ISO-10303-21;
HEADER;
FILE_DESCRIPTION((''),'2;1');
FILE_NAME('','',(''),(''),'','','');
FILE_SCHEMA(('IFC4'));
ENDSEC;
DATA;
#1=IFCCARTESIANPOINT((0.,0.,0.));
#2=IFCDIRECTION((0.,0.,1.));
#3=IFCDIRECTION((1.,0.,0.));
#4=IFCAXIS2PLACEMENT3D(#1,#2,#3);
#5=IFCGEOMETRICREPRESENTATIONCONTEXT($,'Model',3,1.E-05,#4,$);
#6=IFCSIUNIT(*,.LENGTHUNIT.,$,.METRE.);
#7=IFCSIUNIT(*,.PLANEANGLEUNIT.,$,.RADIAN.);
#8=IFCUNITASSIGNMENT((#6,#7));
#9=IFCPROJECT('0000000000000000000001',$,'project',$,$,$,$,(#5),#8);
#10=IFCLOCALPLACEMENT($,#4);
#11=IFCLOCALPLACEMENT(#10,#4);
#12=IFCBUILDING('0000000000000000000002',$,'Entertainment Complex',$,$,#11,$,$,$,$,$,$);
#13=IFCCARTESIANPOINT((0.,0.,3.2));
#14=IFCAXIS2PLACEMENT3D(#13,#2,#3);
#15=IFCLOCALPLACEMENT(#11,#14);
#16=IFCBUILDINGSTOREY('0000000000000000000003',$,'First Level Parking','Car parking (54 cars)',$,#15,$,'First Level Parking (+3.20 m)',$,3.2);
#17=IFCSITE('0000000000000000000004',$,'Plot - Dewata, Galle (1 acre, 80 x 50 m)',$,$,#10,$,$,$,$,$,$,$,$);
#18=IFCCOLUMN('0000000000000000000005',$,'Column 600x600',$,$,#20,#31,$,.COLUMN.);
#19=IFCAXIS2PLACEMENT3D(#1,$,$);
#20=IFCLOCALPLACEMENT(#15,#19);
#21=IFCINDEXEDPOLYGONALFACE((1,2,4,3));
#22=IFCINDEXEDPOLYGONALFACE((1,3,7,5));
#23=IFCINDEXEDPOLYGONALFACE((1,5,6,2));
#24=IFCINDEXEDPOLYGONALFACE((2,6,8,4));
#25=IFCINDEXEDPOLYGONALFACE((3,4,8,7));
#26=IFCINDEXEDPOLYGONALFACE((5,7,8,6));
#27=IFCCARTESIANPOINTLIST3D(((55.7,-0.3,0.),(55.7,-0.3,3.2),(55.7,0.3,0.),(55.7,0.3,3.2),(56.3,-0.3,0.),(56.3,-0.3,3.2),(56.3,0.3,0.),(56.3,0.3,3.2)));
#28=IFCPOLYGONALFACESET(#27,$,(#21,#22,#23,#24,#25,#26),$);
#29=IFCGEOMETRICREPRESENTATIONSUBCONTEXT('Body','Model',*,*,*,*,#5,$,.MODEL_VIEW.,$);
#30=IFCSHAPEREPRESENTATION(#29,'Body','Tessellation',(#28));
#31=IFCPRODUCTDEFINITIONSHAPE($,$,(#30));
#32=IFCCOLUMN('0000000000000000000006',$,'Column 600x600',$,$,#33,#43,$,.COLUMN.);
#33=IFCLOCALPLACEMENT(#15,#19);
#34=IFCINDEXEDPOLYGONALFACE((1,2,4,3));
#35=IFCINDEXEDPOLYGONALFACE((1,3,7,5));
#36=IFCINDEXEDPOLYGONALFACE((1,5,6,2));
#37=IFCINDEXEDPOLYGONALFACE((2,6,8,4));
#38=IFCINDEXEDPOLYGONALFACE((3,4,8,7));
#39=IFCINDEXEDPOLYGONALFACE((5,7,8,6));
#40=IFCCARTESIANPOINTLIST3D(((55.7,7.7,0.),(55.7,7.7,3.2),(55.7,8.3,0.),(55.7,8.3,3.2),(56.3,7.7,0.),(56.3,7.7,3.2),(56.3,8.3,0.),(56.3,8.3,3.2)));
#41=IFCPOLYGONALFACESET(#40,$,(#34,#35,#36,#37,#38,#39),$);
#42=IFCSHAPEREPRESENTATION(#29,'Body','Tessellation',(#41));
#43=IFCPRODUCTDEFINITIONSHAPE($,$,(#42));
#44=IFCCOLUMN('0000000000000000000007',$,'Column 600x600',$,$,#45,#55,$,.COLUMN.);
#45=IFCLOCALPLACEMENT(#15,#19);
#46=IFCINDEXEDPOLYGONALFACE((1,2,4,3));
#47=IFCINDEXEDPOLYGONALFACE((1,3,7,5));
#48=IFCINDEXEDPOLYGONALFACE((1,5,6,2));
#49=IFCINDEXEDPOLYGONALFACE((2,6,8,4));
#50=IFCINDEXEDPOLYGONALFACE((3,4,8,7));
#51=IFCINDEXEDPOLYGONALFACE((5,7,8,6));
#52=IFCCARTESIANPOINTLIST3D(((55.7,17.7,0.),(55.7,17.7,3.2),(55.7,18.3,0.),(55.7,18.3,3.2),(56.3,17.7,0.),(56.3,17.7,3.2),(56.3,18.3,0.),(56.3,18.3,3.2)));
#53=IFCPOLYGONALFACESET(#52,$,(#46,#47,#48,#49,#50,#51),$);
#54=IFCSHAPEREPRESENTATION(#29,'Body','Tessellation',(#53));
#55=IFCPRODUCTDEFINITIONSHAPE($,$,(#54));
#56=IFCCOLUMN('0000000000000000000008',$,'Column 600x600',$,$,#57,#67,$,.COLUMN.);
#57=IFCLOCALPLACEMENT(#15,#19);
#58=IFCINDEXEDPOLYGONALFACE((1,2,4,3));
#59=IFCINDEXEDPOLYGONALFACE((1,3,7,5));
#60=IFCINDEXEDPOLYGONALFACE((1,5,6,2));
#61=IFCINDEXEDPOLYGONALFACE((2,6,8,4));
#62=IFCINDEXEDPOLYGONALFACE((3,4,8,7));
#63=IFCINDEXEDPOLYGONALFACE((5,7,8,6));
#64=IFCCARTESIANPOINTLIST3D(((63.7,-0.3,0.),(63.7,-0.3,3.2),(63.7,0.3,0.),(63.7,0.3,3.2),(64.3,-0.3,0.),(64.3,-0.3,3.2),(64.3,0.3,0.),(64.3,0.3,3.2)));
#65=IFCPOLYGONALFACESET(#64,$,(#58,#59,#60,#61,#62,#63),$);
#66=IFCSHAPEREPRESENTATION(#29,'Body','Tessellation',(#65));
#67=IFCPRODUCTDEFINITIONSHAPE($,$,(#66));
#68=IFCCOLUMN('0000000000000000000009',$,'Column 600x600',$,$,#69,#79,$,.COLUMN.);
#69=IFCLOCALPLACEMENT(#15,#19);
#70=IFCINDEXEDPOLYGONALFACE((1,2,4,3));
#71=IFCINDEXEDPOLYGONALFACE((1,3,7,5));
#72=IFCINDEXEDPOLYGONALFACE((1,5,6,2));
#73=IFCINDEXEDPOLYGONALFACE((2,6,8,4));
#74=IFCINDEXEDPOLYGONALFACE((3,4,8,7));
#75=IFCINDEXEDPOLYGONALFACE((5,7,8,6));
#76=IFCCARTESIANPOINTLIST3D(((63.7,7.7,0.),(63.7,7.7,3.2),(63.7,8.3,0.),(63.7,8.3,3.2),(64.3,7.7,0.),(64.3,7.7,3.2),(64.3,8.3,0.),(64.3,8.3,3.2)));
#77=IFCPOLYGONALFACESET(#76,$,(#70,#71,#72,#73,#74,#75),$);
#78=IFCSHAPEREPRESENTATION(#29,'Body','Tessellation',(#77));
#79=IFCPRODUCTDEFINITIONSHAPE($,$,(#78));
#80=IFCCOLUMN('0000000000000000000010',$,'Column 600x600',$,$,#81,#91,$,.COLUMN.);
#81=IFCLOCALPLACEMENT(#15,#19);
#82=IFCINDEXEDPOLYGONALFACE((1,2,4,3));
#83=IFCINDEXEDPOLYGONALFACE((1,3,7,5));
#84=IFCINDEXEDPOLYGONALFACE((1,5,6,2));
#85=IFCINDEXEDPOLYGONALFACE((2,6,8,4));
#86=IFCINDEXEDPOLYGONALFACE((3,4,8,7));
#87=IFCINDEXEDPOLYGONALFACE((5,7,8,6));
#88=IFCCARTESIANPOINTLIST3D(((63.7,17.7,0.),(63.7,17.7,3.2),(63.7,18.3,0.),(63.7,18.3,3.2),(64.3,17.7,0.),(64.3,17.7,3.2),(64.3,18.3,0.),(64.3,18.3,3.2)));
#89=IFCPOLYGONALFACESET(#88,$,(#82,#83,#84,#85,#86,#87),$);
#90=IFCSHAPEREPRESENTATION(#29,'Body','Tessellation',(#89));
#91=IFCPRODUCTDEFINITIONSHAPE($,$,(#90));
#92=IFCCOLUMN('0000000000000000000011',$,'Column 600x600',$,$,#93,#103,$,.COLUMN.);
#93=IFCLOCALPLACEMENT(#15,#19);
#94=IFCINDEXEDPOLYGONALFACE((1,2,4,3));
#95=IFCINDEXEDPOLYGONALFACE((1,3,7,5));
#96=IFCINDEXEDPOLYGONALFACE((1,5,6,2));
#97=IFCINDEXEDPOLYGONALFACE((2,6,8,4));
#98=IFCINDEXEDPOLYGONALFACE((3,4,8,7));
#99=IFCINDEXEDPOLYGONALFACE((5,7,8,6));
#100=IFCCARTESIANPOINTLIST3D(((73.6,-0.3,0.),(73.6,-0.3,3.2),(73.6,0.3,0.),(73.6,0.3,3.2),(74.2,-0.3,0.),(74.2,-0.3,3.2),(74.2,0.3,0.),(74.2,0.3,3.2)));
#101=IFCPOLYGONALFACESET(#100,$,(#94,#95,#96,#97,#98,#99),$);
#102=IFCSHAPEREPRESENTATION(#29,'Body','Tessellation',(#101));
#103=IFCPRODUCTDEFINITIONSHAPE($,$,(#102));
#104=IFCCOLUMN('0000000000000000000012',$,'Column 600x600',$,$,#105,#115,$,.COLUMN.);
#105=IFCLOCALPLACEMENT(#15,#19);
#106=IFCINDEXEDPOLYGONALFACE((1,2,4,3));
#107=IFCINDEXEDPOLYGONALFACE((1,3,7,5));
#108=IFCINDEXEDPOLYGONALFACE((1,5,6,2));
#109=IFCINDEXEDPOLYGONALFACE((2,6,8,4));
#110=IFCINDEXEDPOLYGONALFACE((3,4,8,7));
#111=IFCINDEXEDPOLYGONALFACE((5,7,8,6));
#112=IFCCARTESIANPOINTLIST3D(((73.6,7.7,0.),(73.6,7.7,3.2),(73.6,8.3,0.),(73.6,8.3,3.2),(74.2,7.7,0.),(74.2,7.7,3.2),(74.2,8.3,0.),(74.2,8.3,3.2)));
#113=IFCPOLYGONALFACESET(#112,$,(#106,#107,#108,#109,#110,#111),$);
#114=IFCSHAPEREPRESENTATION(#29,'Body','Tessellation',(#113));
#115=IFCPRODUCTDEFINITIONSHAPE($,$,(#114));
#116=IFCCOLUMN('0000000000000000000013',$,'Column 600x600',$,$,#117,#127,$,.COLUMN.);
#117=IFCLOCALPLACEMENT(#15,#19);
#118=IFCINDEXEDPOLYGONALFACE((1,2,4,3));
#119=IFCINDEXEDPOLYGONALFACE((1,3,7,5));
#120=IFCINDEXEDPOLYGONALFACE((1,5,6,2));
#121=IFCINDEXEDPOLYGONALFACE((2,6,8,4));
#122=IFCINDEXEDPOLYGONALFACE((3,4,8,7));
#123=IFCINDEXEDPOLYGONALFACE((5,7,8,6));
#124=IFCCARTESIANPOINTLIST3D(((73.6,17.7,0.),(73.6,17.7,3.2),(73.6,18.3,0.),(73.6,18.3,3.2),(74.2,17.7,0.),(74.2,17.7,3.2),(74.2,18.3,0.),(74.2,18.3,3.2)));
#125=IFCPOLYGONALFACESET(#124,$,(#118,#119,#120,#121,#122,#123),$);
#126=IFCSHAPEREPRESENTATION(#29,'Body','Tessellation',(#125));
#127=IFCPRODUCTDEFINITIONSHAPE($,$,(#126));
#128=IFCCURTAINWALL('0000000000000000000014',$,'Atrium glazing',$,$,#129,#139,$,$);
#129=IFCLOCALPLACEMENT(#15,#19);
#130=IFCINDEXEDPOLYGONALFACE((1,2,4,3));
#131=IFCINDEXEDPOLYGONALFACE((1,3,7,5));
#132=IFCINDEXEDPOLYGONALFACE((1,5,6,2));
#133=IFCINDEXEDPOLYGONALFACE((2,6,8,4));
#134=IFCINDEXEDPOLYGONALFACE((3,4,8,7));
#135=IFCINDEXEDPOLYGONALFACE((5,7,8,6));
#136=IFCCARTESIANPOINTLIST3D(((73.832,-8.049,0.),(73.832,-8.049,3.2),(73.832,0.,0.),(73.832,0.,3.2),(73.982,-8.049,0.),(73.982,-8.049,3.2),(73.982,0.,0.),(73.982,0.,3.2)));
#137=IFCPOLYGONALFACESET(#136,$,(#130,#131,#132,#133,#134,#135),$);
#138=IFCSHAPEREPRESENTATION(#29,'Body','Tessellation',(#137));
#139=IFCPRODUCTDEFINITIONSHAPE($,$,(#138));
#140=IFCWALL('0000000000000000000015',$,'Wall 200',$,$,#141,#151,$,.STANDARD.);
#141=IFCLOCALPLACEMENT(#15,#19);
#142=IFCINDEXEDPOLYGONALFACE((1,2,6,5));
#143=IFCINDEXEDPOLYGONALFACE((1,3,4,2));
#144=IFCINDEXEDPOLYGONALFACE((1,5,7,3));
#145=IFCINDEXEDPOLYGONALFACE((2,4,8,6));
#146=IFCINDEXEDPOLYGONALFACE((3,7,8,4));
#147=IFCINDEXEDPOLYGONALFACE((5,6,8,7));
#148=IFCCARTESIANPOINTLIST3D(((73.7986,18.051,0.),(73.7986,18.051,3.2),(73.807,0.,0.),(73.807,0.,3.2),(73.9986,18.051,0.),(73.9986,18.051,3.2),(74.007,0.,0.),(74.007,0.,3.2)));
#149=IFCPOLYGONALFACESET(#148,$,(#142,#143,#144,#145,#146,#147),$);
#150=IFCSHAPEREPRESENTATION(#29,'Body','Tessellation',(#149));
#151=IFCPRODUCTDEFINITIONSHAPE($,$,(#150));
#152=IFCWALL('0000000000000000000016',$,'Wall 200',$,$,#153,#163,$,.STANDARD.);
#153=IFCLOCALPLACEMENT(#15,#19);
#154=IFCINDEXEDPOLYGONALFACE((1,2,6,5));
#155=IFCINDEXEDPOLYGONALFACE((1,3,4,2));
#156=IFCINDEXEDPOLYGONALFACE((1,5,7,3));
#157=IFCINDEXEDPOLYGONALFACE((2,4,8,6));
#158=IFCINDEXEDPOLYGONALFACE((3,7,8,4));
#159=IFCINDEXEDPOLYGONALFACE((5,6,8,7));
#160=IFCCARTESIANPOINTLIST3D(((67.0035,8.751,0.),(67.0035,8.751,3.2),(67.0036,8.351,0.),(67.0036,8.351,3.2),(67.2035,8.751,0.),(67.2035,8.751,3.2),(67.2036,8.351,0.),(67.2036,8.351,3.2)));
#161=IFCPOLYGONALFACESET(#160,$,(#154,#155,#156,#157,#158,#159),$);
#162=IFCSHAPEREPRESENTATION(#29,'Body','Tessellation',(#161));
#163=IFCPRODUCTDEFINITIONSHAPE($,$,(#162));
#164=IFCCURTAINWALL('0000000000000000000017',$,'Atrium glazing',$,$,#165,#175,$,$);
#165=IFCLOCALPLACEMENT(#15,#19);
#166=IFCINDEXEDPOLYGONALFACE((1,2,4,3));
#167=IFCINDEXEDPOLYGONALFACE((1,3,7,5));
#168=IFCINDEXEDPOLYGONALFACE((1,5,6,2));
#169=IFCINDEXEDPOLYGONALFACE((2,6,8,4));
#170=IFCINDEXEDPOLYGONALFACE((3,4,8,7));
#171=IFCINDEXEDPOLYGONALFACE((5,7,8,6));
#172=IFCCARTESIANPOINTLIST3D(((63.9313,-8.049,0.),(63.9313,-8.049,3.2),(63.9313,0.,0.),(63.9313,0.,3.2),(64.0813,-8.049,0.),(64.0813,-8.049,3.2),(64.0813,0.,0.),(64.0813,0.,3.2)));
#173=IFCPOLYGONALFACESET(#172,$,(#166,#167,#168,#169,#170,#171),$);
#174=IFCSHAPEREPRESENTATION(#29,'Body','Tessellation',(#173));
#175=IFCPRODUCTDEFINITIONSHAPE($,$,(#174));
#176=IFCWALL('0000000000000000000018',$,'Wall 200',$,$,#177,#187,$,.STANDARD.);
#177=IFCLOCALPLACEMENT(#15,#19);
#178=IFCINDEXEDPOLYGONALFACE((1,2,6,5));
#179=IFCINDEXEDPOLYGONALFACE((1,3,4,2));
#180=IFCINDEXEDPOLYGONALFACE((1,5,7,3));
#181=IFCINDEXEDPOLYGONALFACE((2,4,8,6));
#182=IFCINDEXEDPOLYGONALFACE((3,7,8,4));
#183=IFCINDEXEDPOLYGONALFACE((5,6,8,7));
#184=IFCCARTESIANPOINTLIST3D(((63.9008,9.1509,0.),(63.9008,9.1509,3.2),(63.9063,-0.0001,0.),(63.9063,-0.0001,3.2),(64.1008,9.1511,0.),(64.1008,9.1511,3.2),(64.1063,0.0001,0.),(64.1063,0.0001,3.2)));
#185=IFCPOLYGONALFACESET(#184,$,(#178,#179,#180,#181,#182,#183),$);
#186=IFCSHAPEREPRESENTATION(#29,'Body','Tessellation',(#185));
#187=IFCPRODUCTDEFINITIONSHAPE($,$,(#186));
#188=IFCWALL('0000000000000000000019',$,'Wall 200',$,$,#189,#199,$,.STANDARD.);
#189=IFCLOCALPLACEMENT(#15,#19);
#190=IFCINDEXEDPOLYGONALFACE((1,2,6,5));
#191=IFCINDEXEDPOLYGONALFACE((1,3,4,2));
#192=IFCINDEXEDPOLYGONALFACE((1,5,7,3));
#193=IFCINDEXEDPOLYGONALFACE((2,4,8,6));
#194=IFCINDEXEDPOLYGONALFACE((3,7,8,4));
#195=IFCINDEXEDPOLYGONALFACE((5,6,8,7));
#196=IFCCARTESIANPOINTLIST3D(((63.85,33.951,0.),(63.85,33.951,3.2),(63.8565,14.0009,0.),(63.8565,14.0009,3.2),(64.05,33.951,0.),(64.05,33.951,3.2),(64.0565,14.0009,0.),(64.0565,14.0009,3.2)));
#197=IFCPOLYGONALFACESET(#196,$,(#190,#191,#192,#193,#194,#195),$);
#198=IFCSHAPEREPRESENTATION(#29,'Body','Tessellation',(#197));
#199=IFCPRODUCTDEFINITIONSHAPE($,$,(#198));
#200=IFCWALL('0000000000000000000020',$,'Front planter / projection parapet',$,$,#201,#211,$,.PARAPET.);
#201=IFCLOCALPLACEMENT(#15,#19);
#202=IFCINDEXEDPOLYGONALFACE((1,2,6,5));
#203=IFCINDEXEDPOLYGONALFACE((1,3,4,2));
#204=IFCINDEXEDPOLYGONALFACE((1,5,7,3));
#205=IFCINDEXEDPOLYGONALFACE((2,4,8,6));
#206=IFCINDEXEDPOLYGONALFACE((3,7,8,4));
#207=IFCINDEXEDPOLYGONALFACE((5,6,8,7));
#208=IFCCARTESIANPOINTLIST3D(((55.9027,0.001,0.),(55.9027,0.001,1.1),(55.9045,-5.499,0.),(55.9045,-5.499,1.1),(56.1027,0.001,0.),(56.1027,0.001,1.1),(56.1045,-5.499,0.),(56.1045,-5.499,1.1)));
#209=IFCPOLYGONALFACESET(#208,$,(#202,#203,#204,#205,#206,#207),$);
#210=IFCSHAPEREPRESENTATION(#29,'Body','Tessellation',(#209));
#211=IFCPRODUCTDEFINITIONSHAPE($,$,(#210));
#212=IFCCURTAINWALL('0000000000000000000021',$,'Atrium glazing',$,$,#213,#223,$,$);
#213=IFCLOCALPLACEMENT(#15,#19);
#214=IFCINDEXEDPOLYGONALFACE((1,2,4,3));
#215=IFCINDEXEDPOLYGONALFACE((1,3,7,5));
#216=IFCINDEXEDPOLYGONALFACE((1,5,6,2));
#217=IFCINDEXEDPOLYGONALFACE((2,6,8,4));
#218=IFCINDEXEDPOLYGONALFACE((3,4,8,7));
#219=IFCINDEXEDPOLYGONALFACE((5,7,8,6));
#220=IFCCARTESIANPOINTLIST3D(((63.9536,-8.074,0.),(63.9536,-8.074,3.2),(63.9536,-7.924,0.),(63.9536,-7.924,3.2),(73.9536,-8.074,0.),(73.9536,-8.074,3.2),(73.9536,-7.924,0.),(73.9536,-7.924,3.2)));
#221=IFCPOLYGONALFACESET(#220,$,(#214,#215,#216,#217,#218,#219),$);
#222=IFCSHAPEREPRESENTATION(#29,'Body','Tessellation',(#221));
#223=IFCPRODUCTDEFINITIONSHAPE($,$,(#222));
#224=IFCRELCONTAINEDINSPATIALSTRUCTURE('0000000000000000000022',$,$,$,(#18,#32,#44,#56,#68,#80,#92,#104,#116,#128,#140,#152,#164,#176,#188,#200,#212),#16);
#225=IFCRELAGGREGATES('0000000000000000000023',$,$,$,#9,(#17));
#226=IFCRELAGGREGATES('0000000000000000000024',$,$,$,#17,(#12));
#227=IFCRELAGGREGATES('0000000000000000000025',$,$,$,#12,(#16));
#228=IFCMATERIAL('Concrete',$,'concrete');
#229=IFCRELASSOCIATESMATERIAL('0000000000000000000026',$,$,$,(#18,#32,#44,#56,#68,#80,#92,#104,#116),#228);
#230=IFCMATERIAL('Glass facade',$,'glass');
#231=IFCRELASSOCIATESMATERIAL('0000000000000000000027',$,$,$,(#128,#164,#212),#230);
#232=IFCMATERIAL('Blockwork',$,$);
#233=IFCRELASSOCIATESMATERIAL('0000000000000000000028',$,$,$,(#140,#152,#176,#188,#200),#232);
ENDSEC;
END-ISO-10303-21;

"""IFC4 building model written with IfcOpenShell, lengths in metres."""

from ifc_helpers import new_model, si_unit, frame, origin_with_axes, place, context, subcontext, project, spatial, polyline, outline, extrude, material, element, save


model = new_model("IFC4")

# Units and contexts
model_context = context("Model", 3, precision=1e-05, world=origin_with_axes())
body_context = subcontext(model_context, "Body", "Model", "MODEL_VIEW")
ifc_project = project(units=[si_unit("LENGTHUNIT", "METRE"), si_unit("PLANEANGLEUNIT", "RADIAN")], contexts=[model_context])

# Site, building, storey
site_placement = place(None, origin_with_axes())
site = spatial("IfcSite", under=ifc_project, at=site_placement, Name="Plot - Dewata, Galle (1 acre, 80 x 50 m)")
building_placement = place(site_placement, origin_with_axes())
building = spatial("IfcBuilding", under=site, at=building_placement, Name="Entertainment Complex")
storey_placement = place(building_placement, frame((0.0, 0.0, 3.2), z_axis=(0.0, 0.0, 1.0), x_axis=(1.0, 0.0, 0.0)))
storey = spatial("IfcBuildingStorey", under=building, at=storey_placement, Name="First Level Parking", Description="Car parking (54 cars)", LongName="First Level Parking (+3.20 m)", Elevation=3.2)

# Columns
ifc_material_1 = material(Name="Concrete", Category="concrete")
for number, where, z_axis, x_axis, name in (
    (1, (56.0, 0.0, 0.0), (0.0, 0.0, 1.0), (1.0, 0.0, 0.0), "Column 600x600"),
    (2, (56.0, 8.0, 0.0), (0.0, 0.0, 1.0), (1.0, 0.0, 0.0), "Column 600x600"),
    (3, (56.0, 18.0, 0.0), (0.0, 0.0, 1.0), (1.0, 0.0, 0.0), "Column 600x600"),
    (4, (64.0, 0.0, 0.0), (0.0, 0.0, 1.0), (1.0, 0.0, 0.0), "Column 600x600"),
    (5, (64.0, 8.0, 0.0), (0.0, 0.0, 1.0), (1.0, 0.0, 0.0), "Column 600x600"),
    (6, (64.0, 18.0, 0.0), (0.0, 0.0, 1.0), (1.0, 0.0, 0.0), "Column 600x600"),
    (7, (73.9, 0.0, 0.0), (0.0, 0.0, 1.0), (1.0, 0.0, 0.0), "Column 600x600"),
    (8, (73.9, 8.0, 0.0), (0.0, 0.0, 1.0), (1.0, 0.0, 0.0), "Column 600x600"),
    (9, (73.9, 18.0, 0.0), (0.0, 0.0, 1.0), (1.0, 0.0, 0.0), "Column 600x600"),
):
    element("IfcColumn", number, at=place(storey_placement, frame(where, z_axis=z_axis, x_axis=x_axis)), inside=storey, material=ifc_material_1, Name=name, PredefinedType="COLUMN", context=body_context, shape_type="SweptSolid", body=[
        extrude(outline(polyline([(-0.3, -0.3), (0.3, -0.3), (0.3, 0.3), (-0.3, 0.3), (-0.3, -0.3)])), origin_with_axes(), (0.0, 0.0, 1.0), 3.2),
    ])

# Curtain wall
ifc_material_2 = material(Name="Glass facade", Category="glass")
curtain_wall_1_placement = place(storey_placement, frame((73.907, -8.049, 0.0), z_axis=(0.0, 0.0, 1.0), x_axis=(0.0, 1.0, 0.0)))
element("IfcCurtainWall", 10, at=curtain_wall_1_placement, inside=storey, material=ifc_material_2, Name="Atrium glazing", context=body_context, shape_type="SweptSolid", body=[
    extrude(outline(polyline([(0.0, -0.075), (8.049, -0.075), (8.049, 0.075), (0.0, 0.075), (0.0, -0.075)])), origin_with_axes(), (0.0, 0.0, 1.0), 3.2),
])

# Walls
ifc_material_3 = material(Name="Blockwork")
wall_1_placement = place(storey_placement, frame((73.907, 0.0, 0.0), z_axis=(0.0, 0.0, 1.0), x_axis=(-0.000465, 1.0, 0.0)))
element("IfcWall", 11, at=wall_1_placement, inside=storey, material=ifc_material_3, Name="Wall 200", PredefinedType="STANDARD", context=body_context, shape_type="SweptSolid", body=[
    extrude(outline(polyline([(0.0, -0.1), (18.051, -0.1), (18.051, 0.1), (0.0, 0.1), (0.0, -0.1)])), origin_with_axes(), (0.0, 0.0, 1.0), 3.2),
])
wall_2_placement = place(storey_placement, frame((67.1036, 8.351, 0.0), z_axis=(0.0, 0.0, 1.0), x_axis=(-0.00025, 1.0, 0.0)))
element("IfcWall", 12, at=wall_2_placement, inside=storey, material=ifc_material_3, Name="Wall 200", PredefinedType="STANDARD", context=body_context, shape_type="SweptSolid", body=[
    extrude(outline(polyline([(0.0, -0.1), (0.4, -0.1), (0.4, 0.1), (0.0, 0.1), (0.0, -0.1)])), origin_with_axes(), (0.0, 0.0, 1.0), 3.2),
])

# Curtain wall
curtain_wall_2_placement = place(storey_placement, frame((64.0063, -8.049, 0.0), z_axis=(0.0, 0.0, 1.0), x_axis=(0.0, 1.0, 0.0)))
element("IfcCurtainWall", 13, at=curtain_wall_2_placement, inside=storey, material=ifc_material_2, Name="Atrium glazing", context=body_context, shape_type="SweptSolid", body=[
    extrude(outline(polyline([(0.0, -0.075), (8.049, -0.075), (8.049, 0.075), (0.0, 0.075), (0.0, -0.075)])), origin_with_axes(), (0.0, 0.0, 1.0), 3.2),
])

# Walls
wall_3_placement = place(storey_placement, frame((64.0063, 0.0, 0.0), z_axis=(0.0, 0.0, 1.0), x_axis=(-0.000601, 1.0, 0.0)))
element("IfcWall", 14, at=wall_3_placement, inside=storey, material=ifc_material_3, Name="Wall 200", PredefinedType="STANDARD", context=body_context, shape_type="SweptSolid", body=[
    extrude(outline(polyline([(0.0, -0.1), (9.151, -0.1), (9.151, 0.1), (0.0, 0.1), (0.0, -0.1)])), origin_with_axes(), (0.0, 0.0, 1.0), 3.2),
])
wall_4_placement = place(storey_placement, frame((63.9565, 14.0009, 0.0), z_axis=(0.0, 0.0, 1.0), x_axis=(-0.000326, 1.0, 0.0)))
element("IfcWall", 15, at=wall_4_placement, inside=storey, material=ifc_material_3, Name="Wall 200", PredefinedType="STANDARD", context=body_context, shape_type="SweptSolid", body=[
    extrude(outline(polyline([(0.0, -0.1), (19.9501, -0.1), (19.9501, 0.1), (0.0, 0.1), (0.0, -0.1)])), origin_with_axes(), (0.0, 0.0, 1.0), 3.2),
])
wall_5_placement = place(storey_placement, frame((56.0045, -5.499, 0.0), z_axis=(0.0, 0.0, 1.0), x_axis=(-0.000327, 1.0, 0.0)))
element("IfcWall", 16, at=wall_5_placement, inside=storey, material=ifc_material_3, Name="Front planter / projection parapet", PredefinedType="PARAPET", context=body_context, shape_type="SweptSolid", body=[
    extrude(outline(polyline([(0.0, -0.1), (5.5, -0.1), (5.5, 0.1), (0.0, 0.1), (0.0, -0.1)])), origin_with_axes(), (0.0, 0.0, 1.0), 1.1),
])

# Curtain wall
curtain_wall_3_placement = place(storey_placement, frame((63.9536, -7.999, 0.0), z_axis=(0.0, 0.0, 1.0), x_axis=(1.0, 0.0, 0.0)))
element("IfcCurtainWall", 17, at=curtain_wall_3_placement, inside=storey, material=ifc_material_2, Name="Atrium glazing", context=body_context, shape_type="SweptSolid", body=[
    extrude(outline(polyline([(0.0, -0.075), (10.0, -0.075), (10.0, 0.075), (0.0, 0.075), (0.0, -0.075)])), origin_with_axes(), (0.0, 0.0, 1.0), 3.2),
])

save(model, "model.ifc")
